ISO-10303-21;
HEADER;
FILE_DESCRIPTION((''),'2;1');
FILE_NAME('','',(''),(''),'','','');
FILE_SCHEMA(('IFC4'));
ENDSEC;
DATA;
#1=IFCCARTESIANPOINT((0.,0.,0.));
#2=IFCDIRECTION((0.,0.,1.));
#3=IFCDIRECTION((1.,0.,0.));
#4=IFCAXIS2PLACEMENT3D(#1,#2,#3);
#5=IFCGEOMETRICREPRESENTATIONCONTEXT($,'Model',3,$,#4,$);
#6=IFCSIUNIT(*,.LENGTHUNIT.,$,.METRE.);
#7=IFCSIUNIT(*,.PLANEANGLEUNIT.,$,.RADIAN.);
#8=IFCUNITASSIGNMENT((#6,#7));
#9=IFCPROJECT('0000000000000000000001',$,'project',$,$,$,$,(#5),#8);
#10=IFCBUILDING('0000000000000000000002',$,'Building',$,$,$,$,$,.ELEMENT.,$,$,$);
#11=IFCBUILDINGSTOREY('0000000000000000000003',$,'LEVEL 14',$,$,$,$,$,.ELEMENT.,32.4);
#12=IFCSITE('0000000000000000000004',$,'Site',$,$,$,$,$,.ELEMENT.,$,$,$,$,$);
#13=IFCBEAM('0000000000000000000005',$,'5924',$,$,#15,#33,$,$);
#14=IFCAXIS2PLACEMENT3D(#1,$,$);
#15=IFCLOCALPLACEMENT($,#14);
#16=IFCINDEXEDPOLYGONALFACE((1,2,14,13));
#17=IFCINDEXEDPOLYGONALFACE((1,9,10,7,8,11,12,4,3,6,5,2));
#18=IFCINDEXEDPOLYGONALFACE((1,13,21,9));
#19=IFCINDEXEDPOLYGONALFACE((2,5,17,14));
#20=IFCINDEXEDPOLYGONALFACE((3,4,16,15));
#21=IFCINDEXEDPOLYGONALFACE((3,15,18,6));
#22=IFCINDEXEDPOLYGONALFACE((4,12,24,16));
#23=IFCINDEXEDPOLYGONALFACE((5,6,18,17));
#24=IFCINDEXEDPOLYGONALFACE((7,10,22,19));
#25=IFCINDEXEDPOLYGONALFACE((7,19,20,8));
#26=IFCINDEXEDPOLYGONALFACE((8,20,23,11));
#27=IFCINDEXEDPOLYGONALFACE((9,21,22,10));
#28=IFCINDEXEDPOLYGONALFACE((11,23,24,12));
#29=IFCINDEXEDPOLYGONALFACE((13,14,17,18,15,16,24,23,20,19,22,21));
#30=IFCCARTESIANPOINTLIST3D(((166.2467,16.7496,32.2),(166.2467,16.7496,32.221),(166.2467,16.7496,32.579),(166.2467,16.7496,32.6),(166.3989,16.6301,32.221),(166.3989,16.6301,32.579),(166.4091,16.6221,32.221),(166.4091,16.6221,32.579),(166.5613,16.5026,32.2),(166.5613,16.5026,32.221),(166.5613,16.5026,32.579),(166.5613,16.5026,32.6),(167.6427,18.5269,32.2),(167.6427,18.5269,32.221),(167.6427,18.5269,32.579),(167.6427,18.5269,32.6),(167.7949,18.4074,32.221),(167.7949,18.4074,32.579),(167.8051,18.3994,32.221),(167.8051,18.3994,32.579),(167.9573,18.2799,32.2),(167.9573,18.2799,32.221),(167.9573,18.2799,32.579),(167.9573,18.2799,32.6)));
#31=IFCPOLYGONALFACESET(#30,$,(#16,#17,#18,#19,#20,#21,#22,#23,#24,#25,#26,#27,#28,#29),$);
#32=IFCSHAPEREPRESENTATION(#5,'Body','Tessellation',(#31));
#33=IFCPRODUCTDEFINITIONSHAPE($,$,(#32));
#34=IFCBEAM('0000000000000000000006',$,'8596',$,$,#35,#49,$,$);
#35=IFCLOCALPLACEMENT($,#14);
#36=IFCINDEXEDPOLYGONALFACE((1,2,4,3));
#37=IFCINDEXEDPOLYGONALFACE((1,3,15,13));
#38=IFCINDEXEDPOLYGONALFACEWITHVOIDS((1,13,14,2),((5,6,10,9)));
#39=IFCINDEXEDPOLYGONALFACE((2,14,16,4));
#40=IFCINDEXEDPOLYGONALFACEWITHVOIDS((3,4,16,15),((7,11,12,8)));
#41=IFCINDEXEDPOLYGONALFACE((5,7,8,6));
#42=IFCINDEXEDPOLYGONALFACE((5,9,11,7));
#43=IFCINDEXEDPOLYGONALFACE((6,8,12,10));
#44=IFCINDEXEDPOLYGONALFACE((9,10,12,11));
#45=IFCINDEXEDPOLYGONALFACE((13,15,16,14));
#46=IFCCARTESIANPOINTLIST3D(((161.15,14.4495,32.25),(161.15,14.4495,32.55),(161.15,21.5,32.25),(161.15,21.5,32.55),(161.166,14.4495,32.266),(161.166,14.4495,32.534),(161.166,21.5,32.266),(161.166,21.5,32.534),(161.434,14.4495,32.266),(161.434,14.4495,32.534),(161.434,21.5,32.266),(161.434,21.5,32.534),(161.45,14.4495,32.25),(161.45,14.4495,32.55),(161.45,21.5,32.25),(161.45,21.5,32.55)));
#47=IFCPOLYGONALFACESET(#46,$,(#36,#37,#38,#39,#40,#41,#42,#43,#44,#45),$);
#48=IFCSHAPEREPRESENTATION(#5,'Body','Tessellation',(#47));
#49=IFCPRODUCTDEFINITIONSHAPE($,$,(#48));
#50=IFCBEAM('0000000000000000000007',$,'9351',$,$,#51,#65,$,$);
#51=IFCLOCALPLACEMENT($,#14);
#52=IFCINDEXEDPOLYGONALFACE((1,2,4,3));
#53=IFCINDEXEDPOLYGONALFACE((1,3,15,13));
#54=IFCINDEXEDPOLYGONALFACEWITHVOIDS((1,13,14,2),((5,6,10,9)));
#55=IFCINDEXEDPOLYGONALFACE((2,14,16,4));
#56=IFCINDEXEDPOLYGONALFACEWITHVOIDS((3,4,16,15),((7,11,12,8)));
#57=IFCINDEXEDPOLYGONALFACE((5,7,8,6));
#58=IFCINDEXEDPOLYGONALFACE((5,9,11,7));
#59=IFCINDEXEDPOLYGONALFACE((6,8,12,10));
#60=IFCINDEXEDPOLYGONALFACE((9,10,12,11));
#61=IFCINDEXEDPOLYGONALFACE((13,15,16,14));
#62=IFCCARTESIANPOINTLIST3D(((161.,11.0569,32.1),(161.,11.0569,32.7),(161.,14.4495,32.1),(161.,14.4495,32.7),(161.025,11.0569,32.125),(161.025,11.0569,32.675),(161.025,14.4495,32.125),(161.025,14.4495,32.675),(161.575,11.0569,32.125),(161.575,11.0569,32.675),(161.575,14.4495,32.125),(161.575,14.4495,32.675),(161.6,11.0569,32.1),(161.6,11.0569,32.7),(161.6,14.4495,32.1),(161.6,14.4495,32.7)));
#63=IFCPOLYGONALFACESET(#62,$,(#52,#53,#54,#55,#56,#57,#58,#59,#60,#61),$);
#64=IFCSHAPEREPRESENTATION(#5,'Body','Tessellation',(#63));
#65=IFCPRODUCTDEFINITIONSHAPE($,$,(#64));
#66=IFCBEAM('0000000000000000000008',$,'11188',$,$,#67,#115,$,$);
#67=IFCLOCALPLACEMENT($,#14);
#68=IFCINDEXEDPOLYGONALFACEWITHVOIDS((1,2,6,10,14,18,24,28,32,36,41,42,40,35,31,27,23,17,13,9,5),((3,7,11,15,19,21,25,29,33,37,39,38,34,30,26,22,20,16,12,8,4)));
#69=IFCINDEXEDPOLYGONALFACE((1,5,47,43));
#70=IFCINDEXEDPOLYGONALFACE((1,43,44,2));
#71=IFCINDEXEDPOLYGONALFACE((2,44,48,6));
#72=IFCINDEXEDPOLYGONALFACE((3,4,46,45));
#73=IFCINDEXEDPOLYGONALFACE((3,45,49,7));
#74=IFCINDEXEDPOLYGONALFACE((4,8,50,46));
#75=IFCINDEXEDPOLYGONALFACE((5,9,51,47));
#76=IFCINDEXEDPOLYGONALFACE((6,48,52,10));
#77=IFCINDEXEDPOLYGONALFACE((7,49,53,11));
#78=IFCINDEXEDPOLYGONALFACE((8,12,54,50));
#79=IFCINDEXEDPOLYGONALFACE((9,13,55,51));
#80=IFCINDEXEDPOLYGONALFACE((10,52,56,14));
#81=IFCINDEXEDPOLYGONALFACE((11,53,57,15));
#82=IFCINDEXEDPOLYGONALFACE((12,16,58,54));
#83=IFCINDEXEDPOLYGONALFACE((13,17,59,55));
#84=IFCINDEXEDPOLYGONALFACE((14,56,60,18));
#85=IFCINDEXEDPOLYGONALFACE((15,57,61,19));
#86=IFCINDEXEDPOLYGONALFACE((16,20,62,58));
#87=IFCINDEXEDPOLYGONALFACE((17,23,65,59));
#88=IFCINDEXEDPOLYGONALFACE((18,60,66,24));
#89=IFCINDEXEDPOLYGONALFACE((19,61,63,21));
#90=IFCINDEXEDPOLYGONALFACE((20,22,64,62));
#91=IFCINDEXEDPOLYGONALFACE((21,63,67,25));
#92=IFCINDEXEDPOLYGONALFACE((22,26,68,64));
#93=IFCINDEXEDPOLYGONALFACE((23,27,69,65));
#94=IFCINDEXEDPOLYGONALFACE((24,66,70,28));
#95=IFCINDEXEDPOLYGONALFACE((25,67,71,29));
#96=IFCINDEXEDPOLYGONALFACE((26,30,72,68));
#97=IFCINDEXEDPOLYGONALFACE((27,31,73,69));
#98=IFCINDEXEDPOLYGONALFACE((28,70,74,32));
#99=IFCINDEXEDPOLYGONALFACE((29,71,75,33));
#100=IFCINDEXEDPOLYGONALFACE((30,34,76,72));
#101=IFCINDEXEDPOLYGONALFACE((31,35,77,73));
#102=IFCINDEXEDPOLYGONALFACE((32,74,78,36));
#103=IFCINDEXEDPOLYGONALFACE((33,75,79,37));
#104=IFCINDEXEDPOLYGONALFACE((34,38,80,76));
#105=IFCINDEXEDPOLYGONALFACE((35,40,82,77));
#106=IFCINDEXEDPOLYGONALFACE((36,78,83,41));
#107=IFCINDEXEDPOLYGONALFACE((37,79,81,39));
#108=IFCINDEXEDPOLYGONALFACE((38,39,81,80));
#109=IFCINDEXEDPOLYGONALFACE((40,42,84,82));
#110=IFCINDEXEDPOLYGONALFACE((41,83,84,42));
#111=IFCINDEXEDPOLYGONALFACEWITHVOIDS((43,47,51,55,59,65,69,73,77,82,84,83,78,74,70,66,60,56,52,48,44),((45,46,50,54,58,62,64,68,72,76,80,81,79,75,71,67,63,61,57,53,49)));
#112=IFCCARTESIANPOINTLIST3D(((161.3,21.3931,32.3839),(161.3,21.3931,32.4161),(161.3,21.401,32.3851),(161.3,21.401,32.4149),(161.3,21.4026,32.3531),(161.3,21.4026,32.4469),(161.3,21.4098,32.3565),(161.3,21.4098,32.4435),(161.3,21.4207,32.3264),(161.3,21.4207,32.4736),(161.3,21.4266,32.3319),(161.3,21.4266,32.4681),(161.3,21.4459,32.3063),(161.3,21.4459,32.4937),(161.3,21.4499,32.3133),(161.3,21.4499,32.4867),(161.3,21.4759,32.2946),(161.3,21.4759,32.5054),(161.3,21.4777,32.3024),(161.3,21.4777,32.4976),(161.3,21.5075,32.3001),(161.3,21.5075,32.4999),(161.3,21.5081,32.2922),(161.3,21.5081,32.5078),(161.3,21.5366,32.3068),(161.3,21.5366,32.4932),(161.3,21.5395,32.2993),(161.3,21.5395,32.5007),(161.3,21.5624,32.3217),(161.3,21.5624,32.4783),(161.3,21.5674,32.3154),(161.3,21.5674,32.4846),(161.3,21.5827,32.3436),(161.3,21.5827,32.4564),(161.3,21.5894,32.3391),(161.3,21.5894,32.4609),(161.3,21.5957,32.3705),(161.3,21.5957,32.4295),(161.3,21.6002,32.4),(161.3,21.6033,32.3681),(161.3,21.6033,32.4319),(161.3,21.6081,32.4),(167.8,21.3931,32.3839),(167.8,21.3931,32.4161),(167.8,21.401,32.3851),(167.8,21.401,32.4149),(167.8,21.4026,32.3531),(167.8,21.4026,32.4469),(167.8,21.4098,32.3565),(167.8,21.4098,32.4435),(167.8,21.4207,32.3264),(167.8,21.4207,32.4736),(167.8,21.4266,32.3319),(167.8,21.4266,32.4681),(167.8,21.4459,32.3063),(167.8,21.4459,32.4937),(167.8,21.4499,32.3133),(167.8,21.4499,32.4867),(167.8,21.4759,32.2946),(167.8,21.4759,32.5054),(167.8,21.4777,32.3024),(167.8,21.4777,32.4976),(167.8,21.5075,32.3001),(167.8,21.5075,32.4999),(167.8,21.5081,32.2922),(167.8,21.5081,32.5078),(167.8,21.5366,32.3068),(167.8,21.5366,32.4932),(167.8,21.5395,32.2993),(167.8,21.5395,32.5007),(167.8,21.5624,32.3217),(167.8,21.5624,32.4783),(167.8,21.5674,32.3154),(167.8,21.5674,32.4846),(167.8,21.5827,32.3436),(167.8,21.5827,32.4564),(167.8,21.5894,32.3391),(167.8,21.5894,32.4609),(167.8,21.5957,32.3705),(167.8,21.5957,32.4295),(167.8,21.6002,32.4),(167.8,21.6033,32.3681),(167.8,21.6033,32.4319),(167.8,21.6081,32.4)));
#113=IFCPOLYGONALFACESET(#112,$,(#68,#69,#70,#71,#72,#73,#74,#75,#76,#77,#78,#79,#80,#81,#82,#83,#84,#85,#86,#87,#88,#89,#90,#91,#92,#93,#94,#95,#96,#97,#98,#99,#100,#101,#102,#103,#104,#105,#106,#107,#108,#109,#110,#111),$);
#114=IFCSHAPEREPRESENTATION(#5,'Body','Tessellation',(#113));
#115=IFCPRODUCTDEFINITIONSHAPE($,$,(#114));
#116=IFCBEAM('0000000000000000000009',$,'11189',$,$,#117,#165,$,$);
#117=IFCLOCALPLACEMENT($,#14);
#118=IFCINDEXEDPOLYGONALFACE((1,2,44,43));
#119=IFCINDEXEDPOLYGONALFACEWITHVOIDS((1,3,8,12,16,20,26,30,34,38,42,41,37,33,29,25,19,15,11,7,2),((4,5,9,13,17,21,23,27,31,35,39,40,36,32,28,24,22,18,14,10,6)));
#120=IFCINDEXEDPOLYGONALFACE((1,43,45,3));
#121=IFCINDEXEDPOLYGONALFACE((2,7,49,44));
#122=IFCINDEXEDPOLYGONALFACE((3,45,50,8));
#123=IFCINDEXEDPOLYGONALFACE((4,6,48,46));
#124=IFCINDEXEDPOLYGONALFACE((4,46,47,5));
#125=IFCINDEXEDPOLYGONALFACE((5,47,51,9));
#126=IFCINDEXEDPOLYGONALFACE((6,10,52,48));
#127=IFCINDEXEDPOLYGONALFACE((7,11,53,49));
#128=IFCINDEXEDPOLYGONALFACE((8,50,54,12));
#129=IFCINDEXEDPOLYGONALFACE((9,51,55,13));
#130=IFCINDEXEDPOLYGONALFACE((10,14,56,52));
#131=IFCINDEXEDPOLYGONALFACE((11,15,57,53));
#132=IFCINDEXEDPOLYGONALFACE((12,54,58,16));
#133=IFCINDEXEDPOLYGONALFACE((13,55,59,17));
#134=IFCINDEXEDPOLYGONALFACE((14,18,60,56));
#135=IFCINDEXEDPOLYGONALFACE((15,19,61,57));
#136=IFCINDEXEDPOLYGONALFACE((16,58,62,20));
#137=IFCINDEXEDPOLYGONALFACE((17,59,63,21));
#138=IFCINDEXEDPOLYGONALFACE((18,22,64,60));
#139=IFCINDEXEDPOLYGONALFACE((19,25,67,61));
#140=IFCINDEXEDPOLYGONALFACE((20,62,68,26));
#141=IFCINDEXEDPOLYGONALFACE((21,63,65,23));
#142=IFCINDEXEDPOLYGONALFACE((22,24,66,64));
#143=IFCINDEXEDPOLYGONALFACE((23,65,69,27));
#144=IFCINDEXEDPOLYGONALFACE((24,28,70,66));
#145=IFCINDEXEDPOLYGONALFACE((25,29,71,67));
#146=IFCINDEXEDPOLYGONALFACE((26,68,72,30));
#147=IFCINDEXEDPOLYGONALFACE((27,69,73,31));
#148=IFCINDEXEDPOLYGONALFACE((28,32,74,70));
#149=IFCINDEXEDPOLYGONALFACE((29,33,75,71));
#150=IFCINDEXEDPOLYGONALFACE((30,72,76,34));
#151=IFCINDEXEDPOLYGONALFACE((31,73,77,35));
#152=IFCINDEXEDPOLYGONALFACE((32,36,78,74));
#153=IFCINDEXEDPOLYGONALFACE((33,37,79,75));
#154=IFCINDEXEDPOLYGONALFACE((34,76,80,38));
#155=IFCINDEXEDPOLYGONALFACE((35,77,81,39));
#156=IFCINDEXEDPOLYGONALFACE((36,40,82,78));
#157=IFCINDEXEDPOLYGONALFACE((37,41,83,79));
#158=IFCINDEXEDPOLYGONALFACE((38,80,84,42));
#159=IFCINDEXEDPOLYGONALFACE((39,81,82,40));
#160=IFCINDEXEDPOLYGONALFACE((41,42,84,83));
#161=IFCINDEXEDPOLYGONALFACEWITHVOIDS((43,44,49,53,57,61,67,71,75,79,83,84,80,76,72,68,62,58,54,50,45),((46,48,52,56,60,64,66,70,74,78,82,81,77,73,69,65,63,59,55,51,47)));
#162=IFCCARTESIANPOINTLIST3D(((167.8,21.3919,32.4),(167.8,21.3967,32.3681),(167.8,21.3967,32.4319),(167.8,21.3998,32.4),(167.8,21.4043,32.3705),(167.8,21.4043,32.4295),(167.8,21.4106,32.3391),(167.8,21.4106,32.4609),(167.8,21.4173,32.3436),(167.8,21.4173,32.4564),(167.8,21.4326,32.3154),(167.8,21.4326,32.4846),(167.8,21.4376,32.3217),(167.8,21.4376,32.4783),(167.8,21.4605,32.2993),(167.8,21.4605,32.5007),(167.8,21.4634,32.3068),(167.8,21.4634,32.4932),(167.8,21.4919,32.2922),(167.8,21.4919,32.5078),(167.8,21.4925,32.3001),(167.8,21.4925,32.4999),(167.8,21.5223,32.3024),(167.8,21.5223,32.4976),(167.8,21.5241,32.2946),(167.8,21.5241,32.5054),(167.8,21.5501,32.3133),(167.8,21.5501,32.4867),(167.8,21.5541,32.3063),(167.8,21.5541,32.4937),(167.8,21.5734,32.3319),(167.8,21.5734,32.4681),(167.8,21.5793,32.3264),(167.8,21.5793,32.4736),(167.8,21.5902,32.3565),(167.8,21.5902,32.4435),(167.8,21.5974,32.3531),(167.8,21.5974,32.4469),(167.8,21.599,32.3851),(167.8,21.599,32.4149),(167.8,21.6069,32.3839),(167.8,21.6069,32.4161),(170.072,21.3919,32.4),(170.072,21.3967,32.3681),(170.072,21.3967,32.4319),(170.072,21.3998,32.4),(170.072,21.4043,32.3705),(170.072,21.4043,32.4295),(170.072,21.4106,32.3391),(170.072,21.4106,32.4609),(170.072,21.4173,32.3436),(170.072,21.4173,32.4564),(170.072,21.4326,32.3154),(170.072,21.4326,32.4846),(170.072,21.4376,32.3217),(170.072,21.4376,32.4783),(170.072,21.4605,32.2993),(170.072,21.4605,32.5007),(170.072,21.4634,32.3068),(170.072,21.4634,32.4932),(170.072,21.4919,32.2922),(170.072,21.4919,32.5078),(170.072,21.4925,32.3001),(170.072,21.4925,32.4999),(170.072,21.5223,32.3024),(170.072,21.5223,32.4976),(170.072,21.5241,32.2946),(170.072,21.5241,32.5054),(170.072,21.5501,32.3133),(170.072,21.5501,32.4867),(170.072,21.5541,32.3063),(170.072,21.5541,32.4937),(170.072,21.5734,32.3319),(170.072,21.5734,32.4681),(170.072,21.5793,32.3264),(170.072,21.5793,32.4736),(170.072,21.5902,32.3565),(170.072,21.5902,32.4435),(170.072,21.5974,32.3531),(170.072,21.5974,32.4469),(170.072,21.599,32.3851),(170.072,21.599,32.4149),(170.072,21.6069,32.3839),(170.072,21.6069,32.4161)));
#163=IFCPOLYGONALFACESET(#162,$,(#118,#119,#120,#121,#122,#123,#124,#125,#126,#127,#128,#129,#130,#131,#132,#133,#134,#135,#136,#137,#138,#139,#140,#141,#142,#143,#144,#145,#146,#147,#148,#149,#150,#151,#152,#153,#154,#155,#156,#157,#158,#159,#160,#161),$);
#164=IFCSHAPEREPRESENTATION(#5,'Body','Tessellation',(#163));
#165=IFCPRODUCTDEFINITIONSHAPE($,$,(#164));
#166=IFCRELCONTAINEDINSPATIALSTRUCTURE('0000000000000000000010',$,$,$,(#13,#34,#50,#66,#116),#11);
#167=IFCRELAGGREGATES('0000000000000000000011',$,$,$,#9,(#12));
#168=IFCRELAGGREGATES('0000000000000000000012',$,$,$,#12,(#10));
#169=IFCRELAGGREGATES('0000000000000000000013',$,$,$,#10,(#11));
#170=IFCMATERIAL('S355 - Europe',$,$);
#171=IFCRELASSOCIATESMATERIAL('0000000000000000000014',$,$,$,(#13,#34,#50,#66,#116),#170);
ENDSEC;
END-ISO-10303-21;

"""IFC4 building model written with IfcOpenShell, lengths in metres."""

from ifc_helpers import new_model, si_unit, frame, origin_with_axes, origin_2d_with_axis, place, context, project, spatial, hollow_rectangle, hollow_circle, i_section, extrude, material, material_profile, profile_set, profile_usage, element, save


model = new_model("IFC4")

# Units and contexts
model_context = context("Model", 3, world=origin_with_axes())
ifc_project = project(units=[si_unit("LENGTHUNIT", "METRE"), si_unit("PLANEANGLEUNIT", "RADIAN")], contexts=[model_context])

# Site, building, storey
site = spatial("IfcSite", under=ifc_project, Name="Site", CompositionType="ELEMENT")
building = spatial("IfcBuilding", under=site, Name="Building", CompositionType="ELEMENT")
storey = spatial("IfcBuildingStorey", under=building, Name="LEVEL 14", CompositionType="ELEMENT", Elevation=32.4)

# Shared definitions
ifc_material = material(Name="S355 - Europe")

# Beams
ifc_material_profile_1 = material_profile(ifc_material, i_section(OverallWidth=0.4, OverallDepth=0.4, WebThickness=0.013, FlangeThickness=0.021, at=origin_2d_with_axis()))
ifc_profile_set_1 = profile_set([ifc_material_profile_1])
ifc_profile_usage_1 = profile_usage(ifc_profile_set_1, cardinal=10)
beam_1_placement = place(None, frame((167.8, 18.4034, 32.4), z_axis=(-0.617698, -0.786415, 0.0), x_axis=(0.786415, -0.617698, 0.0)))
element("IfcBeam", 1, at=beam_1_placement, inside=storey, material=ifc_profile_usage_1, Name="5924", context=model_context, shape_type="SweptSolid", body=[
    extrude(i_section(OverallWidth=0.4, OverallDepth=0.4, WebThickness=0.013, FlangeThickness=0.021, at=origin_2d_with_axis()), origin_with_axes(), (0.0, 0.0, 1.0), 2.26),
])
ifc_material_profile_2 = material_profile(ifc_material, hollow_rectangle(XDim=0.3, YDim=0.3, WallThickness=0.016, at=origin_2d_with_axis()))
ifc_profile_set_2 = profile_set([ifc_material_profile_2])
ifc_profile_usage_2 = profile_usage(ifc_profile_set_2, cardinal=10)
beam_2_placement = place(None, frame((161.3, 21.5, 32.4), z_axis=(0.0, -1.0, 0.0), x_axis=(1.0, 0.0, 0.0)))
element("IfcBeam", 2, at=beam_2_placement, inside=storey, material=ifc_profile_usage_2, Name="8596", context=model_context, shape_type="SweptSolid", body=[
    extrude(hollow_rectangle(XDim=0.3, YDim=0.3, WallThickness=0.016, at=origin_2d_with_axis()), origin_with_axes(), (0.0, 0.0, 1.0), 7.0505),
])
ifc_material_profile_3 = material_profile(ifc_material, hollow_rectangle(XDim=0.6, YDim=0.6, WallThickness=0.025, at=origin_2d_with_axis()))
ifc_profile_set_3 = profile_set([ifc_material_profile_3])
ifc_profile_usage_3 = profile_usage(ifc_profile_set_3, cardinal=10)
beam_3_placement = place(None, frame((161.3, 14.4495, 32.4), z_axis=(0.0, -1.0, 0.0), x_axis=(1.0, 0.0, 0.0)))
element("IfcBeam", 3, at=beam_3_placement, inside=storey, material=ifc_profile_usage_3, Name="9351", context=model_context, shape_type="SweptSolid", body=[
    extrude(hollow_rectangle(XDim=0.6, YDim=0.6, WallThickness=0.025, at=origin_2d_with_axis()), origin_with_axes(), (0.0, 0.0, 1.0), 3.3926),
])
ifc_material_profile_4 = material_profile(ifc_material, hollow_circle(Radius=0.1081, WallThickness=0.008, at=origin_2d_with_axis()))
ifc_profile_set_4 = profile_set([ifc_material_profile_4])
ifc_profile_usage_4 = profile_usage(ifc_profile_set_4, cardinal=10)
beam_4_placement = place(None, frame((161.3, 21.5, 32.4), z_axis=(1.0, 0.0, 0.0), x_axis=(0.0, 1.0, 0.0)))
element("IfcBeam", 4, at=beam_4_placement, inside=storey, material=ifc_profile_usage_4, Name="11188", context=model_context, shape_type="SweptSolid", body=[
    extrude(hollow_circle(Radius=0.1081, WallThickness=0.008, at=origin_2d_with_axis()), origin_with_axes(), (0.0, 0.0, 1.0), 6.5),
])
ifc_material_profile_5 = material_profile(ifc_material, hollow_circle(Radius=0.1081, WallThickness=0.008, at=origin_2d_with_axis()))
ifc_profile_set_5 = profile_set([ifc_material_profile_5])
ifc_profile_usage_5 = profile_usage(ifc_profile_set_5, cardinal=10)
beam_5_placement = place(None, frame((170.072, 21.5, 32.4), z_axis=(-1.0, 0.0, 0.0), x_axis=(0.0, -1.0, 0.0)))
element("IfcBeam", 5, at=beam_5_placement, inside=storey, material=ifc_profile_usage_5, Name="11189", context=model_context, shape_type="SweptSolid", body=[
    extrude(hollow_circle(Radius=0.1081, WallThickness=0.008, at=origin_2d_with_axis()), origin_with_axes(), (0.0, 0.0, 1.0), 2.272),
])

save(model, "model.ifc")
